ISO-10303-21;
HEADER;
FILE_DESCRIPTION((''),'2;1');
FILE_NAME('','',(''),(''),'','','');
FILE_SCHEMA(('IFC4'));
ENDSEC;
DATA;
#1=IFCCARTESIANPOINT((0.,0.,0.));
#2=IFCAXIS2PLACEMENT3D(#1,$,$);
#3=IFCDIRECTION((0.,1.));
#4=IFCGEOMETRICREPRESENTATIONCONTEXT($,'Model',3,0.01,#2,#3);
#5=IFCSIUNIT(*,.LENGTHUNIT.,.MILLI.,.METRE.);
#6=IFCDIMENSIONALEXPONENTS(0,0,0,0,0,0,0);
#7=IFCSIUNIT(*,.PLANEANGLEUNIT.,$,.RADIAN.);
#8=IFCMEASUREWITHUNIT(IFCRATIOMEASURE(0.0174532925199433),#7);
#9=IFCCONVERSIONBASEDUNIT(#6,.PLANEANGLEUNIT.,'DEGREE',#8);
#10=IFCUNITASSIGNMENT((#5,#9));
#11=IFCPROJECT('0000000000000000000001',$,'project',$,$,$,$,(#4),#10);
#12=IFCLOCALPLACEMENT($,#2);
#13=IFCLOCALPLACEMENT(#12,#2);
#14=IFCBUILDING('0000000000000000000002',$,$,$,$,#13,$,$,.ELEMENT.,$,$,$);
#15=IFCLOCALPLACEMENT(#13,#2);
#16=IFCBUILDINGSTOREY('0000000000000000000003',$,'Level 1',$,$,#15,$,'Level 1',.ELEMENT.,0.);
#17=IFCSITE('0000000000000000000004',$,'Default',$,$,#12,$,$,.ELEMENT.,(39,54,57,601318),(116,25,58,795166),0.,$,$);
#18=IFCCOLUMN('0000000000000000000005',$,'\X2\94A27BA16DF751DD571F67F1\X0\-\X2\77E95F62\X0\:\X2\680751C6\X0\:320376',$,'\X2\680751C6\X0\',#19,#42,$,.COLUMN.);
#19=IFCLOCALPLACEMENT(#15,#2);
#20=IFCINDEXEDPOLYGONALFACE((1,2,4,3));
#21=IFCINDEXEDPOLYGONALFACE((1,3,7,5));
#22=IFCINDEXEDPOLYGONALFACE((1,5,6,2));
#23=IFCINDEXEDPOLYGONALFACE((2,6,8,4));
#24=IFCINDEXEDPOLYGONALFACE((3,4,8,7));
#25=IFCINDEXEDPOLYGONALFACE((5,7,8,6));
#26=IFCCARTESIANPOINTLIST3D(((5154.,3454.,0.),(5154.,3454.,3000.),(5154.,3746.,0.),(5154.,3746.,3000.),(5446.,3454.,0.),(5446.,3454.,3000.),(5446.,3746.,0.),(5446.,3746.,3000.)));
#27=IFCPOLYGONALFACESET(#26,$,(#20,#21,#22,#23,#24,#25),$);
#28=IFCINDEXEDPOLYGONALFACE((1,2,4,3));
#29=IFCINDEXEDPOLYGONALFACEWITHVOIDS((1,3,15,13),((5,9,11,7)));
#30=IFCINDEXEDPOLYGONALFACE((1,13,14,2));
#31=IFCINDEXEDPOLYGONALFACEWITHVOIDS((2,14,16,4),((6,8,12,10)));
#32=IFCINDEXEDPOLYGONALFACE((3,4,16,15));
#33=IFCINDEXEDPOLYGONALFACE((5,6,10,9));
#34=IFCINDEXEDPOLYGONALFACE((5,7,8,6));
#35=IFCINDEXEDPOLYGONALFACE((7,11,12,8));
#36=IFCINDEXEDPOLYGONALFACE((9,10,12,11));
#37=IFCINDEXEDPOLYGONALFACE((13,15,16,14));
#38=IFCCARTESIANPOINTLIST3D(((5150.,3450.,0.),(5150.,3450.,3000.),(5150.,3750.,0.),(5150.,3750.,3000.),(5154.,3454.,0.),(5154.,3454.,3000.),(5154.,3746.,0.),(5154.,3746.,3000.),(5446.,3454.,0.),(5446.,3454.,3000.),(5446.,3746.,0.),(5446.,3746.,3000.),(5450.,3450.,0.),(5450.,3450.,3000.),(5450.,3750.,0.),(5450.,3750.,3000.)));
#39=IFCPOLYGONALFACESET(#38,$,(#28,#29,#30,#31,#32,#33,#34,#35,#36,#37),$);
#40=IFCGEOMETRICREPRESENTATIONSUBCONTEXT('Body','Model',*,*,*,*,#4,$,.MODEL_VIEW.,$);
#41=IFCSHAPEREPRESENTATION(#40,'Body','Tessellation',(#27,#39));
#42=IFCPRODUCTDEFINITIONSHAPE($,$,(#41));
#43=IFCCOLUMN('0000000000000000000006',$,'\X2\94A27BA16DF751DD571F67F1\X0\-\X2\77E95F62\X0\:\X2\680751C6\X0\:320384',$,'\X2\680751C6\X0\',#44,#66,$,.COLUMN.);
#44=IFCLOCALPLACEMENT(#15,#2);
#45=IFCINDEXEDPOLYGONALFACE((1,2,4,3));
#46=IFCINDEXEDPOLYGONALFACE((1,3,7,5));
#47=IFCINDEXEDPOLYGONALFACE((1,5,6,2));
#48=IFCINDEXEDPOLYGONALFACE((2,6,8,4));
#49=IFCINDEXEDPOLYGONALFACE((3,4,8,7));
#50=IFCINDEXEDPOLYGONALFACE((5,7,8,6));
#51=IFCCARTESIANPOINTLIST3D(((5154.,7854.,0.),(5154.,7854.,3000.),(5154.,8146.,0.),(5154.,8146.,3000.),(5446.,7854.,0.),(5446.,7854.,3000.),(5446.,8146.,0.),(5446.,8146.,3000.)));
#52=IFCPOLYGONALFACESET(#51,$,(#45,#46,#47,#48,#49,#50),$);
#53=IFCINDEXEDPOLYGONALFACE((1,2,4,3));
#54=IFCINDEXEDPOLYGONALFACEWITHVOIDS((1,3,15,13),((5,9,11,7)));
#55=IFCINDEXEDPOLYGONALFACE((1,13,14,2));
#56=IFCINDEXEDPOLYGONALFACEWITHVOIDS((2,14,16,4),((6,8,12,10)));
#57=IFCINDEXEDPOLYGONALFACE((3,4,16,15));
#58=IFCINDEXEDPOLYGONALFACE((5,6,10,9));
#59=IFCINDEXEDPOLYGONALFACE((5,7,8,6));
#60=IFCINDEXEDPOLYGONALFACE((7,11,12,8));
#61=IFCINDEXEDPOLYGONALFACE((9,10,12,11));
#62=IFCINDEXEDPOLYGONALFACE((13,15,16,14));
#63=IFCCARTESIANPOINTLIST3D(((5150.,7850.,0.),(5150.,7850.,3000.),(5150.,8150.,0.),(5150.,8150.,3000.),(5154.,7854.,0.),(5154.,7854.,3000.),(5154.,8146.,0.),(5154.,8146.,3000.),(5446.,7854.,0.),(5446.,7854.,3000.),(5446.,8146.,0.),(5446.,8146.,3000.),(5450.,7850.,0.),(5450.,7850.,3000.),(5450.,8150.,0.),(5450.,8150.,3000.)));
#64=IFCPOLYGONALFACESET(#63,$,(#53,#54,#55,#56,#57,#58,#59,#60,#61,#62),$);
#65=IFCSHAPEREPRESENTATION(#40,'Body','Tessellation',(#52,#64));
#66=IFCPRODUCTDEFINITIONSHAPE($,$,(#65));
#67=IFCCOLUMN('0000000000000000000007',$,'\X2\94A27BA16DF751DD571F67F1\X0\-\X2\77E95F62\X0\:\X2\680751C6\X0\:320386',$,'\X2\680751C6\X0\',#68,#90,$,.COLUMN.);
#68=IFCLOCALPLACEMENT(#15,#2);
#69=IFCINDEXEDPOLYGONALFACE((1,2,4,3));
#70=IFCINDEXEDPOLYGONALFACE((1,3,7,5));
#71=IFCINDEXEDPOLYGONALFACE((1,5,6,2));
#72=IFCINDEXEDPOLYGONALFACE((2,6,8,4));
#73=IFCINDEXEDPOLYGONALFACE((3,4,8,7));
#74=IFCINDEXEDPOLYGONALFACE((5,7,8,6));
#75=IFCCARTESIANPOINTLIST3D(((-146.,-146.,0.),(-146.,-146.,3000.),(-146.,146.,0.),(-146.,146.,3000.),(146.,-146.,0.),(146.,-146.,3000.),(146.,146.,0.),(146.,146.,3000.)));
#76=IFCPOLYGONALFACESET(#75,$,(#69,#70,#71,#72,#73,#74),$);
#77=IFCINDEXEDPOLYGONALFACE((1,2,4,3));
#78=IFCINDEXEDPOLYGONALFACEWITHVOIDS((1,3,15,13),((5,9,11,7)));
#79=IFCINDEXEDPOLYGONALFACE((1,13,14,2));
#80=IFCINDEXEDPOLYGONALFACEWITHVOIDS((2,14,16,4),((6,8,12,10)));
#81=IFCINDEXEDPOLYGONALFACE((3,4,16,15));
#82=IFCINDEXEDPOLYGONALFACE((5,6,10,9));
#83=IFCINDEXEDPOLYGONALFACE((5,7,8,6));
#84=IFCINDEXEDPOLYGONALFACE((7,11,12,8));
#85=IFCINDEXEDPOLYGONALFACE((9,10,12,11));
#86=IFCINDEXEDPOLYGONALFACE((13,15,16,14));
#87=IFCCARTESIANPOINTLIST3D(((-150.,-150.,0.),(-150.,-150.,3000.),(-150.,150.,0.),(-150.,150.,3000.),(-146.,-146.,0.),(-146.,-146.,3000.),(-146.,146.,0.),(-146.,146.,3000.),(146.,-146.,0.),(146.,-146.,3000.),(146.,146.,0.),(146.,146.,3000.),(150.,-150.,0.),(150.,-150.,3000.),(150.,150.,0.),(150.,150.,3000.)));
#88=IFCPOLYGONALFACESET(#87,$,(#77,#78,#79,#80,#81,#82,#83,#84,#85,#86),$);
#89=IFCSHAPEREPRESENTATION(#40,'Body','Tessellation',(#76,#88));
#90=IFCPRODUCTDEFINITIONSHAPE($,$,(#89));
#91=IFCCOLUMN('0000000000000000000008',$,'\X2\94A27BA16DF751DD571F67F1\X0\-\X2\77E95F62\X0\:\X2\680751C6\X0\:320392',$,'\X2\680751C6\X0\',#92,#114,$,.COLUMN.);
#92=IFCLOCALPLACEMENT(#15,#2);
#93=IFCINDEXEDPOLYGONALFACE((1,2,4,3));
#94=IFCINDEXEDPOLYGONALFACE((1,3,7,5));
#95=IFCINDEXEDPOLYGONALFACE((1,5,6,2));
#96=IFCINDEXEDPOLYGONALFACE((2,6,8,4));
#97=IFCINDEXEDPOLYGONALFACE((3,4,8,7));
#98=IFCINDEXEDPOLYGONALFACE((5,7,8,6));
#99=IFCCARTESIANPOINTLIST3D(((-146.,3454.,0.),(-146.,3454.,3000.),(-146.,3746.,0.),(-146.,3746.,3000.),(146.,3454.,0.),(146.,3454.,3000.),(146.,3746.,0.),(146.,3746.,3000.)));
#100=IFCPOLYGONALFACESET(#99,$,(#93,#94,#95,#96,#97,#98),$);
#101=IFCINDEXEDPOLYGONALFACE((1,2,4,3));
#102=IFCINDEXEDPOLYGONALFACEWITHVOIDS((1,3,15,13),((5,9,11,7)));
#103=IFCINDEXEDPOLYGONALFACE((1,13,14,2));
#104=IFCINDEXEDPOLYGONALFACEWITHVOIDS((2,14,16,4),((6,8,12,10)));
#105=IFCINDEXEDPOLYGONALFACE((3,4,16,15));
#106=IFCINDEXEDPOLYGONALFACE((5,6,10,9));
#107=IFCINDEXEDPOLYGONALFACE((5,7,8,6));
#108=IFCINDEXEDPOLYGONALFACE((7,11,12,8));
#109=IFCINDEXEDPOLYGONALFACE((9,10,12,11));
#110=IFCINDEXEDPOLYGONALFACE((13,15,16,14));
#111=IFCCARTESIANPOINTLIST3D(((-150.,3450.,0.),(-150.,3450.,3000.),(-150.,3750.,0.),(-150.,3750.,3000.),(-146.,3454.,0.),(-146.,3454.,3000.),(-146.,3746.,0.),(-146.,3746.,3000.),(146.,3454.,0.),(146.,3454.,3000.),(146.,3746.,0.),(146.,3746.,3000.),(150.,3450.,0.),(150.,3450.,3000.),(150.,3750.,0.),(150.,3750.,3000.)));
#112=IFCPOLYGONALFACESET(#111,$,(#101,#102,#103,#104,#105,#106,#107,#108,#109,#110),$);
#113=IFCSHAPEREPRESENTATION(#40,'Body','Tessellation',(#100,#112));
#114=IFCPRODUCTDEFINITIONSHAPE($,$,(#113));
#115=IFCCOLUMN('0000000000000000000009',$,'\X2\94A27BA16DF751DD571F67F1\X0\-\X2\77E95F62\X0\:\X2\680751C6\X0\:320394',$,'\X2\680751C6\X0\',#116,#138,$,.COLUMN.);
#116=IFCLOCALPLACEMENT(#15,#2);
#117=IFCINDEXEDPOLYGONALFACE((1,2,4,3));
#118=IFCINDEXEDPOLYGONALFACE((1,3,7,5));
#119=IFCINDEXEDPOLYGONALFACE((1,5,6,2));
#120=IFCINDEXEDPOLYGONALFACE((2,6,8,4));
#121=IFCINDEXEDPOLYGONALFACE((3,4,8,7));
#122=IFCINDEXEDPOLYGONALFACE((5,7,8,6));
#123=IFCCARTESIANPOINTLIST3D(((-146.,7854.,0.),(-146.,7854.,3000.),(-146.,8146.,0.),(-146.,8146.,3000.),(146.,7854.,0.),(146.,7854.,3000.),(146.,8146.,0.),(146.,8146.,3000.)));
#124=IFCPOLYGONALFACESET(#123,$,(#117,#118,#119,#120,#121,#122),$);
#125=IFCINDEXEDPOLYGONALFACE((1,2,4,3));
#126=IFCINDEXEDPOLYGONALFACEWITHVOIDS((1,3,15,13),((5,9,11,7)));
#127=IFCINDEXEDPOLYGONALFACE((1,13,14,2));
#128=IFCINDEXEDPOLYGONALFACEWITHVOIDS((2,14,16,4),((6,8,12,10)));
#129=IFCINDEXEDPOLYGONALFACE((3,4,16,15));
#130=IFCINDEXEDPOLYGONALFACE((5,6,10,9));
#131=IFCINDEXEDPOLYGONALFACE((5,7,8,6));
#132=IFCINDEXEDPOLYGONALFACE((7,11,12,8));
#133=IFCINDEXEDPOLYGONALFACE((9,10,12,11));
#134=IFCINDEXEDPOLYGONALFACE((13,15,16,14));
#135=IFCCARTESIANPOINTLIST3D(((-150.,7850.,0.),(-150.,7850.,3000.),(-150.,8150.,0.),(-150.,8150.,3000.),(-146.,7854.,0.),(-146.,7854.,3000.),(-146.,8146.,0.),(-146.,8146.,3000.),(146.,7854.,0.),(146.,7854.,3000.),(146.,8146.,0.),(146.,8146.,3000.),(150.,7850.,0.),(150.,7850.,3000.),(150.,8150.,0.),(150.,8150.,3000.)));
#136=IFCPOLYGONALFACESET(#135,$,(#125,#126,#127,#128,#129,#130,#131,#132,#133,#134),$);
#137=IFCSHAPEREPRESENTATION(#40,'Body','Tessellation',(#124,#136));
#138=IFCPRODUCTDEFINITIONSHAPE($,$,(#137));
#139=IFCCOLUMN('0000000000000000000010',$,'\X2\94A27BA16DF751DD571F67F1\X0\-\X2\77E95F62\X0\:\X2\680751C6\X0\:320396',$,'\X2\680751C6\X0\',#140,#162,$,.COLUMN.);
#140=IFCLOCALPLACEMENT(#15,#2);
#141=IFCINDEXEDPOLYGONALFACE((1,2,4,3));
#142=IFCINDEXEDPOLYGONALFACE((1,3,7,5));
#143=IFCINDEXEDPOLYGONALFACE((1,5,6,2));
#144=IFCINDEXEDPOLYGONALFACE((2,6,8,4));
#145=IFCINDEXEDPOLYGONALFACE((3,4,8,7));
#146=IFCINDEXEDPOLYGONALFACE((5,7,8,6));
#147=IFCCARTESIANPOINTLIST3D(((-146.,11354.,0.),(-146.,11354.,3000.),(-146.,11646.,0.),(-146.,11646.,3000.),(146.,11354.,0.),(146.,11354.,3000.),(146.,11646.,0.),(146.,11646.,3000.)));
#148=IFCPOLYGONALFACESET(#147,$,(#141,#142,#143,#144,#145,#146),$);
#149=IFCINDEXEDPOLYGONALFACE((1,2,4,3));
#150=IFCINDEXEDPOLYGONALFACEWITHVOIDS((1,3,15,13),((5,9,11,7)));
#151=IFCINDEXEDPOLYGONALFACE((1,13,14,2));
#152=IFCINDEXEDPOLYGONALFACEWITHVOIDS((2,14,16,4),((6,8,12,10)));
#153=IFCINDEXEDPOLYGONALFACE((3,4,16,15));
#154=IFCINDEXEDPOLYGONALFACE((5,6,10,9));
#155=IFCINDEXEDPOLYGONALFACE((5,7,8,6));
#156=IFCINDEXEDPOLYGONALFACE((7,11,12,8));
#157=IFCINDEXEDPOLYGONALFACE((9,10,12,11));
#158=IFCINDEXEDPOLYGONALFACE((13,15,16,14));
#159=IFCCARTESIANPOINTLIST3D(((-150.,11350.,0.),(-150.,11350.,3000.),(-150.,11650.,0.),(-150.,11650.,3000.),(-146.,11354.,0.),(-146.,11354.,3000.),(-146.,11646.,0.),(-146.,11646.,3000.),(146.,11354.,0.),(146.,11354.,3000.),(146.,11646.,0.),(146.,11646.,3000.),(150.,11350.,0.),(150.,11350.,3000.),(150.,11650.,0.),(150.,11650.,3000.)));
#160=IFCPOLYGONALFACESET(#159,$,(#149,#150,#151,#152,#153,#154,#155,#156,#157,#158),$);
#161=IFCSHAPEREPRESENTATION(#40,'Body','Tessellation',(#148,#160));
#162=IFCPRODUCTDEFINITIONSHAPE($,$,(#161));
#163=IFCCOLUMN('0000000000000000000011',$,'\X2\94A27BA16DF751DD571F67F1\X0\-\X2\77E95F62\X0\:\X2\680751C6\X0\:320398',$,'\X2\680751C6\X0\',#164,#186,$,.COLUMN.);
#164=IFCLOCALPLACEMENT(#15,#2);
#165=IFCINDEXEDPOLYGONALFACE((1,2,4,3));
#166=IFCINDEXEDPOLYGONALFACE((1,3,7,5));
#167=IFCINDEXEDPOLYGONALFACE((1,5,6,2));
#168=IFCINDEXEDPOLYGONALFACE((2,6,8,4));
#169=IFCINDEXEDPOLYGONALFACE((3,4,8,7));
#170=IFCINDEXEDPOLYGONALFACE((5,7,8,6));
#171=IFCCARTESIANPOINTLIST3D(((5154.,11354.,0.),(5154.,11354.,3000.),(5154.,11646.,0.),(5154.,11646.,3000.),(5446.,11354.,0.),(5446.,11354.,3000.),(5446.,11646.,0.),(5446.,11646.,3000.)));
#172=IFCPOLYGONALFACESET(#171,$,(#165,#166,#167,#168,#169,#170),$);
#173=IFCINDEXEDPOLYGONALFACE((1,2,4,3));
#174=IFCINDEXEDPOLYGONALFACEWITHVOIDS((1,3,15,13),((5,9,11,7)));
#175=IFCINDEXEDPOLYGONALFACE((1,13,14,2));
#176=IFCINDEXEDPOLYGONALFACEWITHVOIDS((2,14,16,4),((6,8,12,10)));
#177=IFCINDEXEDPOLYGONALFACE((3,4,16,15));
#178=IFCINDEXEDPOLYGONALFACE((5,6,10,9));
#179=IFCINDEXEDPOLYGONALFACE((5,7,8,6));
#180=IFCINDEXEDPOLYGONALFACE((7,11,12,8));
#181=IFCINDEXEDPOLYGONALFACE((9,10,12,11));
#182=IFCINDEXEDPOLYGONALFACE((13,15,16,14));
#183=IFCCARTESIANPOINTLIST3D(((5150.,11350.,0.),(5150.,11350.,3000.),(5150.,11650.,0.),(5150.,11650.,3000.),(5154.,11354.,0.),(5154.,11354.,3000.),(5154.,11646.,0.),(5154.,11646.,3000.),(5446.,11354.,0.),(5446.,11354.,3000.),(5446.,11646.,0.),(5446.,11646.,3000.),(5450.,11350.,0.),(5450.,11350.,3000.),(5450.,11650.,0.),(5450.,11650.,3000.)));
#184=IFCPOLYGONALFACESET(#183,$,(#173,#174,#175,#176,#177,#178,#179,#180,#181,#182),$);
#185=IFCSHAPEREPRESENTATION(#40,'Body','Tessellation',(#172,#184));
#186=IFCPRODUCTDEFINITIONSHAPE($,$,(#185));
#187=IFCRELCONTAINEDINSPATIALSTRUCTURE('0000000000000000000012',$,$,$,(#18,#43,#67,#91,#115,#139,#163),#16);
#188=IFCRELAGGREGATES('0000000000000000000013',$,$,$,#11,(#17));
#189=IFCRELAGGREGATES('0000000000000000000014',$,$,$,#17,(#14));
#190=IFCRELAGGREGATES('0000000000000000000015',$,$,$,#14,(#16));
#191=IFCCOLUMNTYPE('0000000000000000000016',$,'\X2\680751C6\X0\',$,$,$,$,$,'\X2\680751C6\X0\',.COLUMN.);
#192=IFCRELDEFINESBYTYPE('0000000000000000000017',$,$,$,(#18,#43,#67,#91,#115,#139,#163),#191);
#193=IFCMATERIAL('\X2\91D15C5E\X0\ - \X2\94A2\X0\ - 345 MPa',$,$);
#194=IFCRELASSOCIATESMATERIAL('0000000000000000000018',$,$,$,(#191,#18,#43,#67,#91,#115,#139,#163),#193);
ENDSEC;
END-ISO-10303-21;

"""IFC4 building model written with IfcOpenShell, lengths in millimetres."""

from ifc_helpers import new_model, entity, si_unit, converted_unit, direction, frame, origin, origin_2d_with_axis, place, context, subcontext, project, spatial, polyline, rectangle, outline, extrude, source, transform, mapped, material, type_object, type_shapes, element, save


model = new_model("IFC4")

# Units and contexts
model_context = context("Model", 3, precision=0.01, world=origin(), true_north=direction((0.0, 1.0)))
body_context = subcontext(model_context, "Body", "Model", "MODEL_VIEW")
ifc_project = project(units=[si_unit("LENGTHUNIT", "METRE", prefix="MILLI"), converted_unit("PLANEANGLEUNIT", "DEGREE", entity("IfcRatioMeasure", 0.0174532925199433), si_unit("PLANEANGLEUNIT", "RADIAN"), dimensions=[0, 0, 0, 0, 0, 0, 0])], contexts=[model_context])

# Site, building, storey
site_placement = place(None, origin())
site = spatial("IfcSite", under=ifc_project, at=site_placement, Name="Default", CompositionType="ELEMENT", RefLatitude=(39, 54, 57, 601318), RefLongitude=(116, 25, 58, 795166), RefElevation=0.0)
building_placement = place(site_placement, origin())
building = spatial("IfcBuilding", under=site, at=building_placement, CompositionType="ELEMENT")
storey_placement = place(building_placement, origin())
storey = spatial("IfcBuildingStorey", under=building, at=storey_placement, Name="Level 1", LongName="Level 1", CompositionType="ELEMENT", Elevation=0.0)

# Columns
ifc_material_1 = material(Name="金属 - 钢 - 345 MPa")
column_type = type_object("IfcColumnType", Name="标准", ElementType="标准", PredefinedType="COLUMN", material=ifc_material_1)
shared_shape_1 = source(origin(), body_context, "Body", "SweptSolid", [
    extrude(rectangle(XDim=292.0, YDim=292.0, at=origin_2d_with_axis()), frame((0.0, 0.0, 0.0), z_axis=(0.0, 0.0, 1.0), x_axis=(-1.0, 0.0, 0.0)), (0.0, 0.0, 1.0), 3000.0),
    extrude(outline(polyline([(-150.0, -150.0), (150.0, -150.0), (150.0, 150.0), (-150.0, 150.0), (-150.0, -150.0)]), holes=[polyline([(-146.0, -146.0), (-146.0, 146.0), (146.0, 146.0), (146.0, -146.0), (-146.0, -146.0)])]), frame((0.0, 0.0, 0.0), z_axis=(0.0, 0.0, 1.0), x_axis=(-1.0, 0.0, 0.0)), (0.0, 0.0, 1.0), 3000.0),
])
type_shapes(column_type, [shared_shape_1])
for number, where, name in (
    (1, (5300.0, 3600.0, 0.0), "钢管混凝土柱-矩形:标准:320376"),
    (2, (5300.0, 8000.0, 0.0), "钢管混凝土柱-矩形:标准:320384"),
    (3, (0.0, 0.0, 0.0), "钢管混凝土柱-矩形:标准:320386"),
    (4, (0.0, 3600.0, 0.0), "钢管混凝土柱-矩形:标准:320392"),
    (5, (0.0, 8000.0, 0.0), "钢管混凝土柱-矩形:标准:320394"),
    (6, (0.0, 11500.0, 0.0), "钢管混凝土柱-矩形:标准:320396"),
    (7, (5300.0, 11500.0, 0.0), "钢管混凝土柱-矩形:标准:320398"),
):
    element("IfcColumn", number, at=place(storey_placement, frame(where)), inside=storey, type_object=column_type, material=ifc_material_1, Name=name, ObjectType="标准", PredefinedType="COLUMN", context=body_context, shape_type="MappedRepresentation", body=[
        mapped(shared_shape_1, transform((0.0, 0.0, 0.0), scale=1.0)),
    ])

save(model, "model.ifc")
